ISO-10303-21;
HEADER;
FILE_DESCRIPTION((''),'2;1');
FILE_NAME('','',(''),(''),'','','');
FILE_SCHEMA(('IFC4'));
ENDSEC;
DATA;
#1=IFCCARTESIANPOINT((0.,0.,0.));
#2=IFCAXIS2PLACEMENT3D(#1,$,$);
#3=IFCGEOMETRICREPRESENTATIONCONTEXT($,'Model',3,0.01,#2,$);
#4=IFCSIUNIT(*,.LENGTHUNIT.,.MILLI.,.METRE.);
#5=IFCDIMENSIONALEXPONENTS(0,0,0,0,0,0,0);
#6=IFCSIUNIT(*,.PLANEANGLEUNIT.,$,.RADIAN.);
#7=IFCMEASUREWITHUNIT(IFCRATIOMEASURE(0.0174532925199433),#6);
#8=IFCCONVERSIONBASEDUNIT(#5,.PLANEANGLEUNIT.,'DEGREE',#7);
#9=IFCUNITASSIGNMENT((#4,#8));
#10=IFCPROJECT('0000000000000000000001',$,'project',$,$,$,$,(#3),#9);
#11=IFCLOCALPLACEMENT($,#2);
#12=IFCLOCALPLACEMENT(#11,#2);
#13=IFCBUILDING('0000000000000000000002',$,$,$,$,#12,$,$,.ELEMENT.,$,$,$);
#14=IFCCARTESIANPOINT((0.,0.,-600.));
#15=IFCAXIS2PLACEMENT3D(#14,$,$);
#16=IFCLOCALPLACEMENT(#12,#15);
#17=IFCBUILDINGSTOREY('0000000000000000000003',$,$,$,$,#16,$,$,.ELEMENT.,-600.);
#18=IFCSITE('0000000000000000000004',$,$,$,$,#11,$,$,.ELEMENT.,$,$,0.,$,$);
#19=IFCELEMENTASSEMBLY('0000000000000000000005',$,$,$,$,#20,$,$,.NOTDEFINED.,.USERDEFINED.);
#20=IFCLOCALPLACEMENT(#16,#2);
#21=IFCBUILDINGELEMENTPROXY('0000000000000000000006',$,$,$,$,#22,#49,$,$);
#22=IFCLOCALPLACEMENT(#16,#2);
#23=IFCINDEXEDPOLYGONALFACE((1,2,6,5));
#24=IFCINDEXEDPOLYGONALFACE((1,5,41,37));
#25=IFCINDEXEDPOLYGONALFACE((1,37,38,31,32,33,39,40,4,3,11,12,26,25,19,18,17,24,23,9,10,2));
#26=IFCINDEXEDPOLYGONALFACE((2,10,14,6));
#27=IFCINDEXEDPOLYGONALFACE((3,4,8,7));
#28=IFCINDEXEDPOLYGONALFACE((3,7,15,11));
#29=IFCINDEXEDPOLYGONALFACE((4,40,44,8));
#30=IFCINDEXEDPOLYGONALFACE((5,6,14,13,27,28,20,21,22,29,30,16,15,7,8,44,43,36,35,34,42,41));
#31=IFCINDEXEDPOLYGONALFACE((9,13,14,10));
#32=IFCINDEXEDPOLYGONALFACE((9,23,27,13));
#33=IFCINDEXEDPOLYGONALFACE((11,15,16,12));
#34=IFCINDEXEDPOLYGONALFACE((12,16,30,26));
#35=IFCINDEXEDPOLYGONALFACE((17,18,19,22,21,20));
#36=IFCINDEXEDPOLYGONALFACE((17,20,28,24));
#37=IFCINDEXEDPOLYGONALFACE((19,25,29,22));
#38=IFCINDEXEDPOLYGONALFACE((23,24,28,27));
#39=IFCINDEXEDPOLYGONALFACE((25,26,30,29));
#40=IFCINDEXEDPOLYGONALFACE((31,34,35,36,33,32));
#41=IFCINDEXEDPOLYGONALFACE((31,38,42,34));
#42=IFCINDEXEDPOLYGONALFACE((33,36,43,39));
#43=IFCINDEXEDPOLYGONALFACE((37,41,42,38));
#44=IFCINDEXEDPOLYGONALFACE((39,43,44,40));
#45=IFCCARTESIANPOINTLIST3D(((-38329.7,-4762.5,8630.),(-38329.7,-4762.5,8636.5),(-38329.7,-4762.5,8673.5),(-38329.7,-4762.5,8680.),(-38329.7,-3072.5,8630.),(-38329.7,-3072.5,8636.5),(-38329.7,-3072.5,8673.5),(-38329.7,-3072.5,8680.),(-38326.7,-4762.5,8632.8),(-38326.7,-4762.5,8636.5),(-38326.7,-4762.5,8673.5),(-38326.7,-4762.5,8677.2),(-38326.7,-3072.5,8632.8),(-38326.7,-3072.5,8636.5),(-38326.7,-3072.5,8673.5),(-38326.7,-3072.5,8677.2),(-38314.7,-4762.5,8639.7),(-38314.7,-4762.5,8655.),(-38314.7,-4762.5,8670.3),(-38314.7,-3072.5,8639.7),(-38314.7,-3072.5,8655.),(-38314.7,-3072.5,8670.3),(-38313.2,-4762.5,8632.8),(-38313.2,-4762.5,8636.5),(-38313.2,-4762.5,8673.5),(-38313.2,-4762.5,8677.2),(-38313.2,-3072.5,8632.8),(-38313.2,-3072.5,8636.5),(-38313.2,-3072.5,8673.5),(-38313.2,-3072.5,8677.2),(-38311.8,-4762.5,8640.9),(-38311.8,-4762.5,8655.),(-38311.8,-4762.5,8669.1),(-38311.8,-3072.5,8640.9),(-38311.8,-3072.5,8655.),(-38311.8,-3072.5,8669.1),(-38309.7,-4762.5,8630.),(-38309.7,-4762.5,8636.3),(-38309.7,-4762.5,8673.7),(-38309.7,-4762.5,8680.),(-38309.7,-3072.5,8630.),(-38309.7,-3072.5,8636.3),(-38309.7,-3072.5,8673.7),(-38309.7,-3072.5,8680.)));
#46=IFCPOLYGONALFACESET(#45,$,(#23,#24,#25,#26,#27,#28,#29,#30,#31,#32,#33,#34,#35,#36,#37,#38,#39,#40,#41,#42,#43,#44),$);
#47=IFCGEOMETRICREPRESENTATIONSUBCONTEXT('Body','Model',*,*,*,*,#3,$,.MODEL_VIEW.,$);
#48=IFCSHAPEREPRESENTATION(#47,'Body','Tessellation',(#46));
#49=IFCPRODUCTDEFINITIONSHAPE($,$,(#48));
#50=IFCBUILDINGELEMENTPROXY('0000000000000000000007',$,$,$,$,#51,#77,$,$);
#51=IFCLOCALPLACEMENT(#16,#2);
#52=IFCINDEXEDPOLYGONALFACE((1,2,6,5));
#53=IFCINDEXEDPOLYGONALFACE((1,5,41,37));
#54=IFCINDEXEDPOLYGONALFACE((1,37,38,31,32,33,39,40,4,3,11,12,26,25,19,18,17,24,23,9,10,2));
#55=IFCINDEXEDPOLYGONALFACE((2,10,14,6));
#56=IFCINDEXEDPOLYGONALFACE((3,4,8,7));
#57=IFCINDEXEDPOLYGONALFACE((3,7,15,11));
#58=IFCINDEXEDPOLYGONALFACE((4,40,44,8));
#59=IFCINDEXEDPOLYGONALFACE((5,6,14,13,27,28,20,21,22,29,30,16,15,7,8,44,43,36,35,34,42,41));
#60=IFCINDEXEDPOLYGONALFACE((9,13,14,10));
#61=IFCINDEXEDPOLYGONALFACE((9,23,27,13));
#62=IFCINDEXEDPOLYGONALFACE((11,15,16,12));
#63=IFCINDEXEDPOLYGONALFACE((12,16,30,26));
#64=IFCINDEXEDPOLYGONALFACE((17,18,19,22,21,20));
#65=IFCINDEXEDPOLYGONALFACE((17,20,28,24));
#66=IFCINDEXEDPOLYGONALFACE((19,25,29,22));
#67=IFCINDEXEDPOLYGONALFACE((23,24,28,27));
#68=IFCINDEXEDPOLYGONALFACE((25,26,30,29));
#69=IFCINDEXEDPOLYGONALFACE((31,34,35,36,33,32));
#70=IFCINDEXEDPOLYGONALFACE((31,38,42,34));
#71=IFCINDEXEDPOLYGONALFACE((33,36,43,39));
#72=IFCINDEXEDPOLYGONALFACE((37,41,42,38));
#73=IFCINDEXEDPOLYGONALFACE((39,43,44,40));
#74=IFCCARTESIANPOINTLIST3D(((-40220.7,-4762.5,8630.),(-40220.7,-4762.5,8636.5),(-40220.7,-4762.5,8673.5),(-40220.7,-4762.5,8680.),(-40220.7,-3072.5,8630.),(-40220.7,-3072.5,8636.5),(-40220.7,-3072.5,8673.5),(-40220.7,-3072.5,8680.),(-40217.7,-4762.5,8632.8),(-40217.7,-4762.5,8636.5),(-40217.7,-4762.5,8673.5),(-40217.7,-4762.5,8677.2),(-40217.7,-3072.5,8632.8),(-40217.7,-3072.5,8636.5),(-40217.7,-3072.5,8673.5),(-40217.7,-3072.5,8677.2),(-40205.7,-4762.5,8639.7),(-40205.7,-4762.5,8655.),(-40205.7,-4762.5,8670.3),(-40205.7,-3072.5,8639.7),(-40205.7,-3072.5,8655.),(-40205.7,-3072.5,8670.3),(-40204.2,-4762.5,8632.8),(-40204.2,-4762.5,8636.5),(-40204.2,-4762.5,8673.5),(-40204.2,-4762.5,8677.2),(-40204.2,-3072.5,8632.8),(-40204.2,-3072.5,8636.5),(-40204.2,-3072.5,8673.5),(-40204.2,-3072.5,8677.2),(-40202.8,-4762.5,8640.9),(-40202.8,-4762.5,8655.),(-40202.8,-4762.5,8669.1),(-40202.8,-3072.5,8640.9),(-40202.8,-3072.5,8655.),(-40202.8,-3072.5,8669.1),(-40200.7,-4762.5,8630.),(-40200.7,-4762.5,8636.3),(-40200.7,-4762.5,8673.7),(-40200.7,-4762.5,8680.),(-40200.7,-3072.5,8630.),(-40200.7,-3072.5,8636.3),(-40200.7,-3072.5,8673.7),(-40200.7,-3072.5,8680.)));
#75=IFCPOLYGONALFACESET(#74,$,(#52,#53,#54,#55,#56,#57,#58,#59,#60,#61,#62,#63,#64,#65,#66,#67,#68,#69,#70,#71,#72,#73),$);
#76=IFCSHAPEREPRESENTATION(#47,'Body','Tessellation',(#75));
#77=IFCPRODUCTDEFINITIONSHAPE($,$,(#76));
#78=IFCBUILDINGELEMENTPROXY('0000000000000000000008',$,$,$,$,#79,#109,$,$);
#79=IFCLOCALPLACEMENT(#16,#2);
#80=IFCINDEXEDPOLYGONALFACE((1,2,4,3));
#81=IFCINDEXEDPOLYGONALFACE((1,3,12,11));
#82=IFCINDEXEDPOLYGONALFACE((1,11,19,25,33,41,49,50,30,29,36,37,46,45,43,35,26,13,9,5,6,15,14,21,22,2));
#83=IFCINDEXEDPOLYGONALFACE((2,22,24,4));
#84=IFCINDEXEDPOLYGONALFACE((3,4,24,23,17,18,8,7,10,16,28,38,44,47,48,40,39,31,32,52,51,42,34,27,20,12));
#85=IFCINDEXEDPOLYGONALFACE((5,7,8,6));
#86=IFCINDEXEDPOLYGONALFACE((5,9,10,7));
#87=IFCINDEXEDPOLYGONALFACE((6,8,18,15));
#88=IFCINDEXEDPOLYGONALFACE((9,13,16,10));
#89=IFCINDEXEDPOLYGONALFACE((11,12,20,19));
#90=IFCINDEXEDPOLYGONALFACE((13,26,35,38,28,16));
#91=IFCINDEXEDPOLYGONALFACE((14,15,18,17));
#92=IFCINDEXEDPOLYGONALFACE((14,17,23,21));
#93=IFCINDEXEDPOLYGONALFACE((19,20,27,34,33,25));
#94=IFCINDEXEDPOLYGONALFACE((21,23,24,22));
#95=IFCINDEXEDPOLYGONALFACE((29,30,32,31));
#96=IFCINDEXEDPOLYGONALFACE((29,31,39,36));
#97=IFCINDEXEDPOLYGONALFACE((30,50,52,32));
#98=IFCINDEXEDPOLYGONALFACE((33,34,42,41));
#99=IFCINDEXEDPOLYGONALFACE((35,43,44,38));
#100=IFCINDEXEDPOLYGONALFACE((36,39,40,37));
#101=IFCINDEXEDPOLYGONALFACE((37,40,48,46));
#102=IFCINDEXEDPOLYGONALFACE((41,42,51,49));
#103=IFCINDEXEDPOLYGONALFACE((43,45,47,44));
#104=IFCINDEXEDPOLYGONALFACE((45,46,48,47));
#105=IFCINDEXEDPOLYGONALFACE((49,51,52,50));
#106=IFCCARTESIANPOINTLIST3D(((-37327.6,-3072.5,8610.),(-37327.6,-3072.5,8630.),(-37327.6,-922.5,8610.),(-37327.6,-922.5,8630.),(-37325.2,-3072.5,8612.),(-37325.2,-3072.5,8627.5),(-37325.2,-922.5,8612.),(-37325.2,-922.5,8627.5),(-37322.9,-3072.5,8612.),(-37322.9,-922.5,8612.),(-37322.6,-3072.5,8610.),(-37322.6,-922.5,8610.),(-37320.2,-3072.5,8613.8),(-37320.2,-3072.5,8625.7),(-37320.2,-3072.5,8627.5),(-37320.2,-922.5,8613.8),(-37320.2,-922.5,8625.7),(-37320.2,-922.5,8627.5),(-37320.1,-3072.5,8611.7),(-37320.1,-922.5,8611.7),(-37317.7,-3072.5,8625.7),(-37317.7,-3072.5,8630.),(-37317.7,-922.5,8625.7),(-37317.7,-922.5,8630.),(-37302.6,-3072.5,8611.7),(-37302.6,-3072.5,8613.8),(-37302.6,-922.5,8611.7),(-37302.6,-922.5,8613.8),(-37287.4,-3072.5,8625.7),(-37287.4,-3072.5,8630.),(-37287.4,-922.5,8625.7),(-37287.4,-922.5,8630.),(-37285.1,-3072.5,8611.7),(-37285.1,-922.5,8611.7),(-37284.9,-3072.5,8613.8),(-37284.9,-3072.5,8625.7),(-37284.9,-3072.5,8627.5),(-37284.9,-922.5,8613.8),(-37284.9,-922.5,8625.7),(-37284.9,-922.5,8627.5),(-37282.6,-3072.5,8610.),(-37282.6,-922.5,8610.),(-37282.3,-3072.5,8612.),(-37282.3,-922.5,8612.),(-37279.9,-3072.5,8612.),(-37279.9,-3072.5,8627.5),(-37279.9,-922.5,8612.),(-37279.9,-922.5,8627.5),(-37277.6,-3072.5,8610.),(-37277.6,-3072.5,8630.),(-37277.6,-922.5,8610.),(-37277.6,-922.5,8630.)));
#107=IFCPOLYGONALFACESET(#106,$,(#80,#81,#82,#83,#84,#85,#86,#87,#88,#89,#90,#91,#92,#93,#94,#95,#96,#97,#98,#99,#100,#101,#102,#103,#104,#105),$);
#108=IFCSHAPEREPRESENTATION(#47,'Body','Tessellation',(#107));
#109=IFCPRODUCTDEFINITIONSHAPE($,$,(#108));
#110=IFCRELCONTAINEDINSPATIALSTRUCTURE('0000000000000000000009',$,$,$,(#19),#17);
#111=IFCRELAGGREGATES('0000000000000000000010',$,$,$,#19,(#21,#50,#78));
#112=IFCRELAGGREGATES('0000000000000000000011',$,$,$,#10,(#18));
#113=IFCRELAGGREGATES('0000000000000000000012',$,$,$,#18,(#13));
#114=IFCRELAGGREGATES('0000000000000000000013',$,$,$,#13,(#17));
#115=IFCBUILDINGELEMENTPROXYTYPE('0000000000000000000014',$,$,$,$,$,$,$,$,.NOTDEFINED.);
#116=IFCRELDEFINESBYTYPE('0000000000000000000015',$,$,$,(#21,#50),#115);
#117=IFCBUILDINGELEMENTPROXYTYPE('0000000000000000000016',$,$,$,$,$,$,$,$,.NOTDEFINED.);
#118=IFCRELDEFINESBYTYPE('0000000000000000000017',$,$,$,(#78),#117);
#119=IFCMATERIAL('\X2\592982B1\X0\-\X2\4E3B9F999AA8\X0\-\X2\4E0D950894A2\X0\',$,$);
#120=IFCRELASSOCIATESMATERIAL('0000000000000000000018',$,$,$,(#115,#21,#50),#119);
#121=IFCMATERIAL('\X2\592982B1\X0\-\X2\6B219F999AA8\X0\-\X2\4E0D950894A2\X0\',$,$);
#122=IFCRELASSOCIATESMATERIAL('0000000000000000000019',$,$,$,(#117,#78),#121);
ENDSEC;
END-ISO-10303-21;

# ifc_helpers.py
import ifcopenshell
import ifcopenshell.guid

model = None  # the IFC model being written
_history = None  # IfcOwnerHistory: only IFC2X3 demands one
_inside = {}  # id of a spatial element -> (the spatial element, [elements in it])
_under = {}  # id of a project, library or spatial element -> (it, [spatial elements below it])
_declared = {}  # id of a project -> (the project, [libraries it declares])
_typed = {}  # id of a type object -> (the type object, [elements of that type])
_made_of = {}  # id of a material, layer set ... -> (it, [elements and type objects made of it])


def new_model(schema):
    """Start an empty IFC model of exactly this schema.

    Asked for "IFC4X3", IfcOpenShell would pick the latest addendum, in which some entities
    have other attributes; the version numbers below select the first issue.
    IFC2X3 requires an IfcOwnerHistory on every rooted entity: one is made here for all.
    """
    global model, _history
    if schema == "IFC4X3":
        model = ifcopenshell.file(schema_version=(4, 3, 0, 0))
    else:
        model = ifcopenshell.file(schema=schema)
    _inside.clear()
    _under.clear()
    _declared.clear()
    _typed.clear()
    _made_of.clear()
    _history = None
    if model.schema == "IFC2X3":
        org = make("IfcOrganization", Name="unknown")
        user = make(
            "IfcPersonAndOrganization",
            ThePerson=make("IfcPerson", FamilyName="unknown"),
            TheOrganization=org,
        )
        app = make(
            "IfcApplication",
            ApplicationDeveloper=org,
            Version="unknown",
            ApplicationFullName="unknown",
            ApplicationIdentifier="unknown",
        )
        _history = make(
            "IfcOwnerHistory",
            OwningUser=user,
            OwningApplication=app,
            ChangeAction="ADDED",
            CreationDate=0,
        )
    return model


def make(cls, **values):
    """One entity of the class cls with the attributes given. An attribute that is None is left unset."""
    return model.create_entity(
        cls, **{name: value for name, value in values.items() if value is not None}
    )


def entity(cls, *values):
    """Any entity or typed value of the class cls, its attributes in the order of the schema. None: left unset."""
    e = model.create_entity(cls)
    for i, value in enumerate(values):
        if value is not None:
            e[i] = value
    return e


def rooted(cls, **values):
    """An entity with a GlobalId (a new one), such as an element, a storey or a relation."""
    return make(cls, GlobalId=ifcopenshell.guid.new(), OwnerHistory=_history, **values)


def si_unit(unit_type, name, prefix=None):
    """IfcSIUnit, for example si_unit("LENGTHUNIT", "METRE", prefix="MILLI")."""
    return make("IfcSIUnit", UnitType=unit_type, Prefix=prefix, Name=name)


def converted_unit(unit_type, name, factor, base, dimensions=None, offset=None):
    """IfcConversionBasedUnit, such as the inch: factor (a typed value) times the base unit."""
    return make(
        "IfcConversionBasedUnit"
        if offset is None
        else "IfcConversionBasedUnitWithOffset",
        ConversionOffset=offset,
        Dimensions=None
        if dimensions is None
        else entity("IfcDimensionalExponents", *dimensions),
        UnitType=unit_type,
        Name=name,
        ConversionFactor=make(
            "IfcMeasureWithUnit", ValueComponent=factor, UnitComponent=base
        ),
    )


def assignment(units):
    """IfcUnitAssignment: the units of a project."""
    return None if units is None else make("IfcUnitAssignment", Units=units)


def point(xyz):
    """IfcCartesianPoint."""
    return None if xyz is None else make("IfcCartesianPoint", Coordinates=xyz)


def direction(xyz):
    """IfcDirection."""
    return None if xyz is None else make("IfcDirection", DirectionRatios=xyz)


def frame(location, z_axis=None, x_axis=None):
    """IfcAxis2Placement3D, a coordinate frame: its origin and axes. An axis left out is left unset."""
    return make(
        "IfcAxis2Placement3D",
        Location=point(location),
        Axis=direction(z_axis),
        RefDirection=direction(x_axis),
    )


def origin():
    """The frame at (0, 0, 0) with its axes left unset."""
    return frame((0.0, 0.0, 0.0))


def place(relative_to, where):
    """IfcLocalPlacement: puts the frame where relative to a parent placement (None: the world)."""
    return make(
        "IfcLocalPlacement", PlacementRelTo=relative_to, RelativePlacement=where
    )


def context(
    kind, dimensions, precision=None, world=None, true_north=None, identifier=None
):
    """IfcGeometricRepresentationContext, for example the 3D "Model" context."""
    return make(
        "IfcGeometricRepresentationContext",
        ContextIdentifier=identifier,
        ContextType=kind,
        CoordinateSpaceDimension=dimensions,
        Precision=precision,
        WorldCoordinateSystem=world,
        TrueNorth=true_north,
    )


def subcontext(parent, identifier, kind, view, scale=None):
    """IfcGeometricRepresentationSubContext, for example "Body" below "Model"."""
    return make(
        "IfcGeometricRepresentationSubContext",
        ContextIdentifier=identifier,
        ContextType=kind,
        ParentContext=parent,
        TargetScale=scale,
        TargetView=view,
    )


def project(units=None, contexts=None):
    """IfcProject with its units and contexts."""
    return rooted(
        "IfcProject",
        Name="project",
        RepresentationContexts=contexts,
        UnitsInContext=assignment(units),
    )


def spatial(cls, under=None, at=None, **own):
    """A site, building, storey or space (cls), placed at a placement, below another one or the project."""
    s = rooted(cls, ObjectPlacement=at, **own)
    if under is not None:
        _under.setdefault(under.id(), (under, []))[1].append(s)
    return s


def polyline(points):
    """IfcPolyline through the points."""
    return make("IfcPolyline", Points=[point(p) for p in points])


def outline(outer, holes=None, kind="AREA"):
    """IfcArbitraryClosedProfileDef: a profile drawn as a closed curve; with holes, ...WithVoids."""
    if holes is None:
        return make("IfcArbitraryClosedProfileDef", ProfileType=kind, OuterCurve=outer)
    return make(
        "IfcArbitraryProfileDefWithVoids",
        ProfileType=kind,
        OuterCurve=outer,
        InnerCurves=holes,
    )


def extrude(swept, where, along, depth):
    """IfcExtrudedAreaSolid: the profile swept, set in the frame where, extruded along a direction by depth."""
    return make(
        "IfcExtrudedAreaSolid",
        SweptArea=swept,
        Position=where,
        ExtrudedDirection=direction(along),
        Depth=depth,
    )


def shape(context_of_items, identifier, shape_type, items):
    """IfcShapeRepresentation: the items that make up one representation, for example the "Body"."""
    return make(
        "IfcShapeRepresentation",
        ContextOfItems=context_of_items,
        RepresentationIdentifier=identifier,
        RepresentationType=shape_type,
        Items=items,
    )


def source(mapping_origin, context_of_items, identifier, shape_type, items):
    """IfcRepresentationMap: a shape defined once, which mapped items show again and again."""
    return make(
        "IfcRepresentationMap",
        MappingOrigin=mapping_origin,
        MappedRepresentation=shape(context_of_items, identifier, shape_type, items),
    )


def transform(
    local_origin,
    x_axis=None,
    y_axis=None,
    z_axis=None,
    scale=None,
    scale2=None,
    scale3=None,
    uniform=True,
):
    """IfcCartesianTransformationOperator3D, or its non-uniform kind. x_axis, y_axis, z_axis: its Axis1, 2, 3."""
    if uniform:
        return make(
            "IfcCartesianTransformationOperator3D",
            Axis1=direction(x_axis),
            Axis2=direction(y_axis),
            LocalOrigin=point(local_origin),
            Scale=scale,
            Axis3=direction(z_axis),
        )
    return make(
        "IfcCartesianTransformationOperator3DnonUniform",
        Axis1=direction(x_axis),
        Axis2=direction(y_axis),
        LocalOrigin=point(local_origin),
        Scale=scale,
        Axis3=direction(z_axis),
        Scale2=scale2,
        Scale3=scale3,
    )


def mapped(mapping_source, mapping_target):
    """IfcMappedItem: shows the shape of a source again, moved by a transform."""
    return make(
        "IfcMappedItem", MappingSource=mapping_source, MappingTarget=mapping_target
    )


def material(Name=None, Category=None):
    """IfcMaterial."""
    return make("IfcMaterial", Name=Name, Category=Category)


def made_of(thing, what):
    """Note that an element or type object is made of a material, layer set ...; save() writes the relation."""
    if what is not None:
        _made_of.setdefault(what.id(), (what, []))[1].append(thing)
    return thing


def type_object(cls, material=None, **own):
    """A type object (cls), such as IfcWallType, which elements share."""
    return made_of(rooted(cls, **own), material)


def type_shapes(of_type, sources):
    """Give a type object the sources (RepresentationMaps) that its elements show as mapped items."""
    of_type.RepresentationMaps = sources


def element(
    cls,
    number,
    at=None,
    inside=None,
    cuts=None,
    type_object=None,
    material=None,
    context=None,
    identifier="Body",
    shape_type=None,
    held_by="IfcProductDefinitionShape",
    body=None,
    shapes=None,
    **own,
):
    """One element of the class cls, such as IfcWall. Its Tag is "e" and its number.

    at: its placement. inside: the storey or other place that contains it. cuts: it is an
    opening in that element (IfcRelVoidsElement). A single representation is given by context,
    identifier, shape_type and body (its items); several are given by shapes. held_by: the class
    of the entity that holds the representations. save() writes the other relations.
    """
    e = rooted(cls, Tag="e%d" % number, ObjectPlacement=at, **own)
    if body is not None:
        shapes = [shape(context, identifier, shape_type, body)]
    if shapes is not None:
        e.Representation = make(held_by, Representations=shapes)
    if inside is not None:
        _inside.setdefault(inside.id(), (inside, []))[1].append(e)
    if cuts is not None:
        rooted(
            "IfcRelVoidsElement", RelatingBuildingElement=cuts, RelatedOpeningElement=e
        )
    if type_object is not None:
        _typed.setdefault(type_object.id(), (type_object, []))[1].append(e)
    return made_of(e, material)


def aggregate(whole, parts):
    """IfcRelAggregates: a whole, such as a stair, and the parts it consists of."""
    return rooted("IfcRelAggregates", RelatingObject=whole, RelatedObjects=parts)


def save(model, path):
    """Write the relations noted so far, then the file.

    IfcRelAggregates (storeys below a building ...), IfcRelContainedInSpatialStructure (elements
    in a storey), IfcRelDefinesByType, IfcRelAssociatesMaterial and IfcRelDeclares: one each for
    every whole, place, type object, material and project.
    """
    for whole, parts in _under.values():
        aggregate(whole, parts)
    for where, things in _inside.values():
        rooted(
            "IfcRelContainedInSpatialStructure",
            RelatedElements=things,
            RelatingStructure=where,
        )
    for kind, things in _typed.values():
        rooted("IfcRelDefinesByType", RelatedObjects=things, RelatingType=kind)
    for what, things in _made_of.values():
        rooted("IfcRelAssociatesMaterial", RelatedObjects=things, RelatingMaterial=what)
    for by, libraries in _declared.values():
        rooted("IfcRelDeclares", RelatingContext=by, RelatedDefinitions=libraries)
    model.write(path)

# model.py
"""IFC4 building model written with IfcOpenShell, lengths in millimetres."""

from ifc_helpers import new_model, entity, si_unit, converted_unit, frame, origin, place, context, subcontext, project, spatial, polyline, outline, extrude, source, transform, mapped, material, type_object, type_shapes, element, aggregate, save


model = new_model("IFC4")

# Units and contexts
model_context = context("Model", 3, precision=0.01, world=origin())
body_context = subcontext(model_context, "Body", "Model", "MODEL_VIEW")
ifc_project = project(units=[si_unit("LENGTHUNIT", "METRE", prefix="MILLI"), converted_unit("PLANEANGLEUNIT", "DEGREE", entity("IfcRatioMeasure", 0.0174532925199433), si_unit("PLANEANGLEUNIT", "RADIAN"), dimensions=[0, 0, 0, 0, 0, 0, 0])], contexts=[model_context])

# Site, building, storey
site_placement = place(None, origin())
site = spatial("IfcSite", under=ifc_project, at=site_placement, CompositionType="ELEMENT", RefElevation=0.0)
building_placement = place(site_placement, origin())
building = spatial("IfcBuilding", under=site, at=building_placement, CompositionType="ELEMENT")
storey_placement = place(building_placement, frame((0.0, 0.0, -600.0)))
storey = spatial("IfcBuildingStorey", under=building, at=storey_placement, CompositionType="ELEMENT", Elevation=-600.0)

# Element assembly
assembly_1_placement = place(storey_placement, origin())
assembly_1 = element("IfcElementAssembly", 1, at=assembly_1_placement, inside=storey, AssemblyPlace="NOTDEFINED", PredefinedType="USERDEFINED")

# Building element proxies
ifc_material_1 = material(Name="天花-次龙骨-不锈钢")
ifc_material_2 = material(Name="天花-主龙骨-不锈钢")
building_element_proxy_type_1 = type_object("IfcBuildingElementProxyType", PredefinedType="NOTDEFINED", material=ifc_material_2)
shared_shape_1 = source(origin(), body_context, "Body", "SweptSolid", [
    extrude(outline(polyline([(-25.0, -11.7), (-18.5, -11.7), (-18.5, -8.7), (-22.2, -8.7), (-22.2, 4.8), (-18.5, 4.8), (-15.3, 3.3), (0.0, 3.3), (15.3, 3.3), (18.5, 4.8), (22.2, 4.8), (22.2, -8.7), (18.5, -8.7), (18.5, -11.7), (25.0, -11.7), (25.0, 8.3), (18.7, 8.3), (14.1, 6.2), (0.0, 6.2), (-14.1, 6.2), (-18.7, 8.3), (-25.0, 8.3), (-25.0, -11.7)])), frame((0.0, 1.7, 0.0), z_axis=(1.0, 0.0, 0.0), x_axis=(0.0, 0.0, -1.0)), (0.0, 0.0, 1.0), 1690.0),
])
type_shapes(building_element_proxy_type_1, [shared_shape_1])
proxy_1_placement = place(assembly_1_placement, frame((-38319.7, -3072.5, 8655.0), z_axis=(0.0, 0.0, 1.0), x_axis=(0.0, -1.0, 0.0)))
proxy_1 = element("IfcBuildingElementProxy", 2, at=proxy_1_placement, type_object=building_element_proxy_type_1, material=ifc_material_2, context=body_context, shape_type="MappedRepresentation", body=[
    mapped(shared_shape_1, transform((0.0, 0.0, 0.0), scale=1.0)),
])
proxy_2_placement = place(assembly_1_placement, frame((-40210.7, -3072.5, 8655.0), z_axis=(0.0, 0.0, 1.0), x_axis=(0.0, -1.0, 0.0)))
proxy_2 = element("IfcBuildingElementProxy", 3, at=proxy_2_placement, type_object=building_element_proxy_type_1, material=ifc_material_2, context=body_context, shape_type="MappedRepresentation", body=[
    mapped(shared_shape_1, transform((0.0, 0.0, 0.0), scale=1.0)),
])
building_element_proxy_type_2 = type_object("IfcBuildingElementProxyType", PredefinedType="NOTDEFINED", material=ifc_material_1)
shared_shape_2 = source(origin(), body_context, "Body", "SweptSolid", [
    extrude(outline(polyline([(-25.0, -9.1), (-20.0, -9.1), (-17.5, -7.4), (0.0, -7.4), (17.5, -7.4), (20.0, -9.1), (25.0, -9.1), (25.0, 10.9), (15.1, 10.9), (15.1, 6.6), (17.6, 6.6), (17.6, 8.4), (22.6, 8.4), (22.6, -7.1), (20.3, -7.1), (17.6, -5.3), (0.0, -5.3), (-17.6, -5.3), (-20.3, -7.1), (-22.6, -7.1), (-22.6, 8.4), (-17.6, 8.4), (-17.6, 6.6), (-15.1, 6.6), (-15.1, 10.9), (-25.0, 10.9), (-25.0, -9.1)])), frame((0.0, 0.0, -0.9), z_axis=(1.0, 0.0, 0.0), x_axis=(0.0, 1.0, 0.0)), (0.0, 0.0, 1.0), 2150.0),
])
type_shapes(building_element_proxy_type_2, [shared_shape_2])
proxy_3_placement = place(assembly_1_placement, frame((-37302.6, -922.5, 8620.0), z_axis=(0.0, 0.0, 1.0), x_axis=(0.0, -1.0, 0.0)))
proxy_3 = element("IfcBuildingElementProxy", 4, at=proxy_3_placement, type_object=building_element_proxy_type_2, material=ifc_material_1, context=body_context, shape_type="MappedRepresentation", body=[
    mapped(shared_shape_2, transform((0.0, 0.0, 0.0), scale=1.0)),
])
aggregate(assembly_1, [proxy_1, proxy_2, proxy_3])

save(model, "model.ifc")
